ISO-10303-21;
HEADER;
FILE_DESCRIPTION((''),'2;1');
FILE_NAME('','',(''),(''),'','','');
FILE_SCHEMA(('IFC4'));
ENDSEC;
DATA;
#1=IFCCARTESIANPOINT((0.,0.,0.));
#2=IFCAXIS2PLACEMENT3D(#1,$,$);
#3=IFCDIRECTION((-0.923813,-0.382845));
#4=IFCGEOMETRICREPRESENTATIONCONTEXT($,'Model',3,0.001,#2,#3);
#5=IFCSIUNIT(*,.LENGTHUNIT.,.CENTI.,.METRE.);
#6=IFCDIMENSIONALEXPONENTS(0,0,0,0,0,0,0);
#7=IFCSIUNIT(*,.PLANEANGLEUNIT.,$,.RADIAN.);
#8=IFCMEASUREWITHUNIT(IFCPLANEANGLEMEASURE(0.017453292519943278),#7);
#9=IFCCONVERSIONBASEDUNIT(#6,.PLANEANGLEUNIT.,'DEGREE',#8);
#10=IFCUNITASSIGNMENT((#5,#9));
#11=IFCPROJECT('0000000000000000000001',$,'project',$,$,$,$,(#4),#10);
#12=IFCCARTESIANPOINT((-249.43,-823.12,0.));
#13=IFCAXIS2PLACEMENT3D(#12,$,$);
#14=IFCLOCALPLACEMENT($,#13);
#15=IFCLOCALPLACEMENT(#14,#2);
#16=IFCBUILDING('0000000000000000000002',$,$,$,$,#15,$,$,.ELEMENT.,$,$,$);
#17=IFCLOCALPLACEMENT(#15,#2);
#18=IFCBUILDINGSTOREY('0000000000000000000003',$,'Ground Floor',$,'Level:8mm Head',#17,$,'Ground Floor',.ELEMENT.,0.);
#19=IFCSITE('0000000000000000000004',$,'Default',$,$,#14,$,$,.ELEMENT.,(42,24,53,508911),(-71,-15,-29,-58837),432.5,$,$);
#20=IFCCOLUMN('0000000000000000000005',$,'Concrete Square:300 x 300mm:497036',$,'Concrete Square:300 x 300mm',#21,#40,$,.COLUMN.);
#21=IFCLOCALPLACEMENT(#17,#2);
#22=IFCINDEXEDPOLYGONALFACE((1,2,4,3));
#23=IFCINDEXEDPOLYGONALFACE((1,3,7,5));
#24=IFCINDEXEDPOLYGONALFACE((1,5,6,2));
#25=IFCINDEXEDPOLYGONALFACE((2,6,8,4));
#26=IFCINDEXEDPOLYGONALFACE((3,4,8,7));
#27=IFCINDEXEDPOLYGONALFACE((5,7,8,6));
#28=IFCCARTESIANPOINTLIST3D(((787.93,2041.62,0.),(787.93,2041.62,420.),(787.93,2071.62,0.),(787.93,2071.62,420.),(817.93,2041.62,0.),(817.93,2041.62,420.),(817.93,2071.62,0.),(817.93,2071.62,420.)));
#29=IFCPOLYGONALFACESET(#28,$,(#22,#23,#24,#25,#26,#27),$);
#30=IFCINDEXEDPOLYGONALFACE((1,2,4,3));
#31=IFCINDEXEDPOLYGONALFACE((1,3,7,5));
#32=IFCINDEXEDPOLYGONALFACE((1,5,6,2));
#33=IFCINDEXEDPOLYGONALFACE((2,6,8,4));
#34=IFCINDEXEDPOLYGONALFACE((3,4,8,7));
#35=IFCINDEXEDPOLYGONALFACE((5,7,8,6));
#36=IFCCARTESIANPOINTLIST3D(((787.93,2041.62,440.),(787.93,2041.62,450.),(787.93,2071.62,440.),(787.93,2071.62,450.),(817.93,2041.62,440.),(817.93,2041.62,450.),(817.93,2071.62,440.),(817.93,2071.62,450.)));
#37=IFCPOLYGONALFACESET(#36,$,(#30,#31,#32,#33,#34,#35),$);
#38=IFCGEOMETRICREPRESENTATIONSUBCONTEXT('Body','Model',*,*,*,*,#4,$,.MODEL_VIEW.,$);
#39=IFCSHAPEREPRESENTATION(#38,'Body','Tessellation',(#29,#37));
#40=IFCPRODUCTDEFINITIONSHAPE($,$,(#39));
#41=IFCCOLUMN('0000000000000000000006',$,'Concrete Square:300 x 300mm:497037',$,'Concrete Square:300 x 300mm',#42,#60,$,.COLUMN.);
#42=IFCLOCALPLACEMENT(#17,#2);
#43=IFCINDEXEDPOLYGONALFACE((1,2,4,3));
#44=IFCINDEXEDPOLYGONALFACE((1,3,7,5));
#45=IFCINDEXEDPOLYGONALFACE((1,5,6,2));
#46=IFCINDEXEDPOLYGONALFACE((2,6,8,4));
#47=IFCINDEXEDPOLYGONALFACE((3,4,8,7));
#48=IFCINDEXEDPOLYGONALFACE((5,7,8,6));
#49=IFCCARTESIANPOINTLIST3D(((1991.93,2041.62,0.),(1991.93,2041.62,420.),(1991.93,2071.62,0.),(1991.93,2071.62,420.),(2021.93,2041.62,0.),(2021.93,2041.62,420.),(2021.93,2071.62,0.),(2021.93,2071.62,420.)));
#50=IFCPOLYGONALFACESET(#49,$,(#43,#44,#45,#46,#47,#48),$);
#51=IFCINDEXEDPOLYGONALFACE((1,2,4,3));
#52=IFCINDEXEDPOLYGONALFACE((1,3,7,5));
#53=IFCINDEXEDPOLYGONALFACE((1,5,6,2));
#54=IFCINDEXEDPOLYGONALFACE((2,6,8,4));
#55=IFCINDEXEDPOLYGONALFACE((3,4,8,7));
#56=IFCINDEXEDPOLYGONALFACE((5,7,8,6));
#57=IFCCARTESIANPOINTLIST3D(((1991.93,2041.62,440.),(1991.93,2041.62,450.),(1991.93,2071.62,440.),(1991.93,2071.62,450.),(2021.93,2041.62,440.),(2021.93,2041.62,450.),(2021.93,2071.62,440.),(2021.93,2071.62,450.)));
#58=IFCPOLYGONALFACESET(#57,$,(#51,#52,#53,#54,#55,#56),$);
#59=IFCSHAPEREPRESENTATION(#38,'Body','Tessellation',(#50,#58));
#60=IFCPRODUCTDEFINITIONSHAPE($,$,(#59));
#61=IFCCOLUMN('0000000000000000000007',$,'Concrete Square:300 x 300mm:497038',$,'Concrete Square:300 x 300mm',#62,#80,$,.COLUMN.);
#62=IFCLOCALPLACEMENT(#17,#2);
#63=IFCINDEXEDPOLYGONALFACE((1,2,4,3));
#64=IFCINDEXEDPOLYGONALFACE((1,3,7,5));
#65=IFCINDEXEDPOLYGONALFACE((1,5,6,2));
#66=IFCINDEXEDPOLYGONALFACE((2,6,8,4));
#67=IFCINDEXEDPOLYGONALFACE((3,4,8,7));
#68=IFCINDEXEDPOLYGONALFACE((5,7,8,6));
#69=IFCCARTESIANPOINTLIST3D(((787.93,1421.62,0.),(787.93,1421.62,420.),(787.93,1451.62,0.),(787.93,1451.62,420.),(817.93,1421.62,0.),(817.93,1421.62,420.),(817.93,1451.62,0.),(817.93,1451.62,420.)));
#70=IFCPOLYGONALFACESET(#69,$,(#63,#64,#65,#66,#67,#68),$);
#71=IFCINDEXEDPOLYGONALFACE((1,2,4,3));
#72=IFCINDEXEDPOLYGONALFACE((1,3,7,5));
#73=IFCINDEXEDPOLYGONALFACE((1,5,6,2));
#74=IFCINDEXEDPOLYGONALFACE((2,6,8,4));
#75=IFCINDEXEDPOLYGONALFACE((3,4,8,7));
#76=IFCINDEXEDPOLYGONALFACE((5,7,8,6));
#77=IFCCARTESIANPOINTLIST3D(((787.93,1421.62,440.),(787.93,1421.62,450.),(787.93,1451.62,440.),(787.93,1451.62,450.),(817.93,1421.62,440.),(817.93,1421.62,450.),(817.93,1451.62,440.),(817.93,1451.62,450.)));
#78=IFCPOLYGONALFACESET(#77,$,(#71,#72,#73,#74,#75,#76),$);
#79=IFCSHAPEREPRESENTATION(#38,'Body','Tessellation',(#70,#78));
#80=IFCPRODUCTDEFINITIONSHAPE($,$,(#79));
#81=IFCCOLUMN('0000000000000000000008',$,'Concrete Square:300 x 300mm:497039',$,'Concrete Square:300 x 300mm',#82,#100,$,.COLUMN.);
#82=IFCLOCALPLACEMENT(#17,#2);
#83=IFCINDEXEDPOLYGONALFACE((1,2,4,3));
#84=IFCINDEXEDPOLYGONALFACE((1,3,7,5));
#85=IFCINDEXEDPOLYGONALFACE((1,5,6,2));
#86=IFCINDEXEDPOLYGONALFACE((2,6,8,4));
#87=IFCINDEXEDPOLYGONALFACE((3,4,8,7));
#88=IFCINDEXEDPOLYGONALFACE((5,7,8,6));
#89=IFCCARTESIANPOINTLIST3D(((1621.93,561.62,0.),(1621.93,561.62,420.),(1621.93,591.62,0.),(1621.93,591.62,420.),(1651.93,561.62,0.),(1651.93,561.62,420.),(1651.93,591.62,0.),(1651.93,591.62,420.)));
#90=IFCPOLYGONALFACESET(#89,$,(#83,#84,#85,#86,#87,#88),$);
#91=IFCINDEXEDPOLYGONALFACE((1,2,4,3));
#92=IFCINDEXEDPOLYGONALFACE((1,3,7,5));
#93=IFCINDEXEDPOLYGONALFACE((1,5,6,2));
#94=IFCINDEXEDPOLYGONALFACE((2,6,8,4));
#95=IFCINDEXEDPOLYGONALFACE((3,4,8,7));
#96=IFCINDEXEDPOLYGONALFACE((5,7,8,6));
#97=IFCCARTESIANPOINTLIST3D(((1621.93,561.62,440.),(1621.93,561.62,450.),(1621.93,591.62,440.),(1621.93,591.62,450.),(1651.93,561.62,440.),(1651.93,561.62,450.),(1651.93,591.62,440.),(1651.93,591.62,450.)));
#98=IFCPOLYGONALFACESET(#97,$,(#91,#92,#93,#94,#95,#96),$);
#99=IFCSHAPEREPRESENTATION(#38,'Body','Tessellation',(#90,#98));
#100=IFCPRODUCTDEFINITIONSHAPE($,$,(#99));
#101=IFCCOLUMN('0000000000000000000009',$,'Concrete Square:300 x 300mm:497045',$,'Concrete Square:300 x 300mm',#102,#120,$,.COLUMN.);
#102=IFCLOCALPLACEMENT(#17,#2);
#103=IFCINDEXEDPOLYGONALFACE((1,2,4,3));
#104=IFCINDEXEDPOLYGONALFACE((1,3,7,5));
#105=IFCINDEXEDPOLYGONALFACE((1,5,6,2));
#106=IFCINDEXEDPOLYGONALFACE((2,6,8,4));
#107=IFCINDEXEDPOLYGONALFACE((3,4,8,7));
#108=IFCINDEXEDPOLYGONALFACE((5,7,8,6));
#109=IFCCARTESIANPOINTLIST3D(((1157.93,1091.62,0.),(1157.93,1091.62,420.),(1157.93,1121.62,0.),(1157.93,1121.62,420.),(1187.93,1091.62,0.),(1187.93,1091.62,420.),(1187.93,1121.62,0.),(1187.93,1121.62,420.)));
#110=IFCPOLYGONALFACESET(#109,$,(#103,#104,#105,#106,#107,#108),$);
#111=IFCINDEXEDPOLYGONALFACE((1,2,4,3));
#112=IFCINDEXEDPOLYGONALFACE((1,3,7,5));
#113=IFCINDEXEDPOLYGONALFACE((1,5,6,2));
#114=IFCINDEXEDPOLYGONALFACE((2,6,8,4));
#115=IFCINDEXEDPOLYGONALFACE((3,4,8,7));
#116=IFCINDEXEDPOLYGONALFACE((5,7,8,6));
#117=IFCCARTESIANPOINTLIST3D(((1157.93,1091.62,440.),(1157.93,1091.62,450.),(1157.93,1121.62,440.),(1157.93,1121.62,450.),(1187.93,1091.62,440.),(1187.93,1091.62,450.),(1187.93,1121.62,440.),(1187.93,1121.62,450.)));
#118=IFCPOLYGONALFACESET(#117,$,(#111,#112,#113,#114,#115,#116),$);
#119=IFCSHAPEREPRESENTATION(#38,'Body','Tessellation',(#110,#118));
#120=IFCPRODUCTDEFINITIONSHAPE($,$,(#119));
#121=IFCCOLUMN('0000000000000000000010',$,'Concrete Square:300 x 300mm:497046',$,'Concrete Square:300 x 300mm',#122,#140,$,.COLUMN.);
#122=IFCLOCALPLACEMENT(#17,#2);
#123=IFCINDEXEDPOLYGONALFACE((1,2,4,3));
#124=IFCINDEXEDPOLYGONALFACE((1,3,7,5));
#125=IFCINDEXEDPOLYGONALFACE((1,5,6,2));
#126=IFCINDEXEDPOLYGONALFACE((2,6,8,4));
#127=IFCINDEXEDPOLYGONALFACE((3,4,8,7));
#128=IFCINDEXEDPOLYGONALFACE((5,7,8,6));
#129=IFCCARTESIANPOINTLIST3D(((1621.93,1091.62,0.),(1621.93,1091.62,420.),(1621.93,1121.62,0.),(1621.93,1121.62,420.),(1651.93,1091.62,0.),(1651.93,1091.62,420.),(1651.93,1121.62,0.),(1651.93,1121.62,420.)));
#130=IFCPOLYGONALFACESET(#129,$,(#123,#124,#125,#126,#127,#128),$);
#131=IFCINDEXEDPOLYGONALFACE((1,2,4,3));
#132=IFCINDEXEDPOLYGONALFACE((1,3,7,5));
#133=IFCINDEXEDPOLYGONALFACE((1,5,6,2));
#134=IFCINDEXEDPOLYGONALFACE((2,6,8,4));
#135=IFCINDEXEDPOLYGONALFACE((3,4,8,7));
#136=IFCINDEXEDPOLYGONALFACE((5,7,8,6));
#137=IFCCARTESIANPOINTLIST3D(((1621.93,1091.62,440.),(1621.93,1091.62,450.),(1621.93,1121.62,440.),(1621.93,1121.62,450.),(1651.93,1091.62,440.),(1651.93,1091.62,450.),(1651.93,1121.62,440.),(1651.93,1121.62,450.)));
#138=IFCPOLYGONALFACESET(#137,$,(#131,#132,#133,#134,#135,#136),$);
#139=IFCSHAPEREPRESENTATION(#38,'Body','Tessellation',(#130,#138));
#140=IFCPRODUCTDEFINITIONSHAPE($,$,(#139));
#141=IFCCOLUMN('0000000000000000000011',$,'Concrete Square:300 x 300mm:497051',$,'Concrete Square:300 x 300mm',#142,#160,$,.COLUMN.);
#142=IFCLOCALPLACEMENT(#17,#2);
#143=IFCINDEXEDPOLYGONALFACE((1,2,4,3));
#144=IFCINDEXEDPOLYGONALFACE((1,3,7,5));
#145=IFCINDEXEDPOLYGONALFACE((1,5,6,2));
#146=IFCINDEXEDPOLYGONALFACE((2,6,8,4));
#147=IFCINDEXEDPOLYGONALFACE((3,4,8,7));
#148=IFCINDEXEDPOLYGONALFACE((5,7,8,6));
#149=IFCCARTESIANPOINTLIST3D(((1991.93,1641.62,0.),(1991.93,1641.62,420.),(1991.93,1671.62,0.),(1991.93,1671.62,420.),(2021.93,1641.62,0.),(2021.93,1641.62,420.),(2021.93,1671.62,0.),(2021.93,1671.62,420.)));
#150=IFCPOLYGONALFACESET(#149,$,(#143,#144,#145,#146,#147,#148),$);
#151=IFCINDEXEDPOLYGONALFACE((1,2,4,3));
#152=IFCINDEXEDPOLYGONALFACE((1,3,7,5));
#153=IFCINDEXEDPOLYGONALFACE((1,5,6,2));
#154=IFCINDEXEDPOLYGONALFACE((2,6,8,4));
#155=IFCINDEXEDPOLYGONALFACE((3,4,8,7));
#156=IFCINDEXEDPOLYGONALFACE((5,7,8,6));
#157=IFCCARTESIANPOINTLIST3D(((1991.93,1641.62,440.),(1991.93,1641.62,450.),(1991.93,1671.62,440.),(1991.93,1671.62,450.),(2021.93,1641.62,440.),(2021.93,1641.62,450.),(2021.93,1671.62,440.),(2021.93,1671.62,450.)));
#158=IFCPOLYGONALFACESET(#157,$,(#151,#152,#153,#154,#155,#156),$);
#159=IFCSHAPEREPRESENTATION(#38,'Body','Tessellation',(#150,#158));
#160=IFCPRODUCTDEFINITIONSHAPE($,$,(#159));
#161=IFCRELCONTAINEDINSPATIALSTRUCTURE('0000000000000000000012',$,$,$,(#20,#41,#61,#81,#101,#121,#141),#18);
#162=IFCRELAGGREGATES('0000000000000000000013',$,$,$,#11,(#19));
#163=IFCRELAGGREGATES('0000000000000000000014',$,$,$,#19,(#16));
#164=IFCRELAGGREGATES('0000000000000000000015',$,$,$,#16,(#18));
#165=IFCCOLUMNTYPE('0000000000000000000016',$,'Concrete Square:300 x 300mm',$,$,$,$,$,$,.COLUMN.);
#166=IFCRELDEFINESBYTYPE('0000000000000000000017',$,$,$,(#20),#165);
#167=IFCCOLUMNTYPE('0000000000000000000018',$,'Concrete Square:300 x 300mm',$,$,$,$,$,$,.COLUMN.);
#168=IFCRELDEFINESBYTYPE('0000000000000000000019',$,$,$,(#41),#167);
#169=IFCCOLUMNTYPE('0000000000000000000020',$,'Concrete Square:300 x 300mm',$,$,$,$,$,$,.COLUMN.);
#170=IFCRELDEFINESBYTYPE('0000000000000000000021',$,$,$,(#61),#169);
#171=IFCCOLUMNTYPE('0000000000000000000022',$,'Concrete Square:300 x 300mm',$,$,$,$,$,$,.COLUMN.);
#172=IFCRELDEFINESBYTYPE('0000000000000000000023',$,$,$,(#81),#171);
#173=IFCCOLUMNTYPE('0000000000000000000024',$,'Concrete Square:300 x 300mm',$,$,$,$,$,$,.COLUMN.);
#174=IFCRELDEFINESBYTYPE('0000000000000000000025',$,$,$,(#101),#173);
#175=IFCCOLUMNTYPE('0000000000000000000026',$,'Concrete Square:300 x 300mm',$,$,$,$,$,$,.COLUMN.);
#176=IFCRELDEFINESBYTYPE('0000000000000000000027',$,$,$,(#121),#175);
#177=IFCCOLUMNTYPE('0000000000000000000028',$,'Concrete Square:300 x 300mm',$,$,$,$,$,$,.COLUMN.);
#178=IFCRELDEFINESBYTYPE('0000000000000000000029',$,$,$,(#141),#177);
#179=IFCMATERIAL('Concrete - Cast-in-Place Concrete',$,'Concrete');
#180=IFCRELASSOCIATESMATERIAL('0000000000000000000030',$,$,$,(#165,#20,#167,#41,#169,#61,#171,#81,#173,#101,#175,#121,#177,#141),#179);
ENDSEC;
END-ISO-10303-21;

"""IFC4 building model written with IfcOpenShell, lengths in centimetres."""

from ifc_helpers import new_model, entity, si_unit, converted_unit, direction, frame, origin, place, context, subcontext, project, spatial, indexed_curve, outline, extrude, source, transform, mapped, material, type_object, type_shapes, element, save


model = new_model("IFC4")

# Units and contexts
model_context = context("Model", 3, precision=0.001, world=origin(), true_north=direction((-0.923813, -0.382845)))
body_context = subcontext(model_context, "Body", "Model", "MODEL_VIEW")
ifc_project = project(units=[si_unit("LENGTHUNIT", "METRE", prefix="CENTI"), converted_unit("PLANEANGLEUNIT", "DEGREE", entity("IfcPlaneAngleMeasure", 0.017453292519943278), si_unit("PLANEANGLEUNIT", "RADIAN"), dimensions=[0, 0, 0, 0, 0, 0, 0])], contexts=[model_context])

# Site, building, storey
site_placement = place(None, frame((-249.43, -823.12, 0.0)))
site = spatial("IfcSite", under=ifc_project, at=site_placement, Name="Default", CompositionType="ELEMENT", RefLatitude=(42, 24, 53, 508911), RefLongitude=(-71, -15, -29, -58837), RefElevation=432.5)
building_placement = place(site_placement, origin())
building = spatial("IfcBuilding", under=site, at=building_placement, CompositionType="ELEMENT")
storey_placement = place(building_placement, origin())
storey = spatial("IfcBuildingStorey", under=building, at=storey_placement, Name="Ground Floor", ObjectType="Level:8mm Head", LongName="Ground Floor", CompositionType="ELEMENT", Elevation=0.0)

# Columns
ifc_material_1 = material(Name="Concrete - Cast-in-Place Concrete", Category="Concrete")
column_type_1 = type_object("IfcColumnType", Name="Concrete Square:300 x 300mm", PredefinedType="COLUMN", material=ifc_material_1)
shared_shape_1 = source(origin(), body_context, "Body", "SweptSolid", [
    extrude(outline(indexed_curve([(-15.0, -15.0), (15.0, -15.0), (15.0, 15.0), (-15.0, 15.0), (-15.0, -15.0)], self_intersect=False)), frame((802.93, 2056.62, 0.0), z_axis=(0.0, 0.0, 1.0), x_axis=(-1.0, 0.0, 0.0)), (0.0, 0.0, 1.0), 420.0),
    extrude(outline(indexed_curve([(-15.0, -15.0), (15.0, -15.0), (15.0, 15.0), (-15.0, 15.0), (-15.0, -15.0)], self_intersect=False)), frame((802.93, 2056.62, 440.0), z_axis=(0.0, 0.0, 1.0), x_axis=(-1.0, 0.0, 0.0)), (0.0, 0.0, 1.0), 10.0),
])
type_shapes(column_type_1, [shared_shape_1])
column_1_placement = place(storey_placement, origin())
element("IfcColumn", 1, at=column_1_placement, inside=storey, type_object=column_type_1, material=ifc_material_1, Name="Concrete Square:300 x 300mm:497036", ObjectType="Concrete Square:300 x 300mm", PredefinedType="COLUMN", context=body_context, shape_type="MappedRepresentation", body=[
    mapped(shared_shape_1, transform((0.0, 0.0, 0.0), scale=1.0)),
])
column_type_2 = type_object("IfcColumnType", Name="Concrete Square:300 x 300mm", PredefinedType="COLUMN", material=ifc_material_1)
shared_shape_2 = source(origin(), body_context, "Body", "SweptSolid", [
    extrude(outline(indexed_curve([(-15.0, -15.0), (15.0, -15.0), (15.0, 15.0), (-15.0, 15.0), (-15.0, -15.0)], self_intersect=False)), frame((2006.93, 2056.62, 0.0), z_axis=(0.0, 0.0, 1.0), x_axis=(-1.0, 0.0, 0.0)), (0.0, 0.0, 1.0), 420.0),
    extrude(outline(indexed_curve([(-15.0, -15.0), (15.0, -15.0), (15.0, 15.0), (-15.0, 15.0), (-15.0, -15.0)], self_intersect=False)), frame((2006.93, 2056.62, 440.0), z_axis=(0.0, 0.0, 1.0), x_axis=(-1.0, 0.0, 0.0)), (0.0, 0.0, 1.0), 10.0),
])
type_shapes(column_type_2, [shared_shape_2])
column_2_placement = place(storey_placement, origin())
element("IfcColumn", 2, at=column_2_placement, inside=storey, type_object=column_type_2, material=ifc_material_1, Name="Concrete Square:300 x 300mm:497037", ObjectType="Concrete Square:300 x 300mm", PredefinedType="COLUMN", context=body_context, shape_type="MappedRepresentation", body=[
    mapped(shared_shape_2, transform((0.0, 0.0, 0.0), scale=1.0)),
])
column_type_3 = type_object("IfcColumnType", Name="Concrete Square:300 x 300mm", PredefinedType="COLUMN", material=ifc_material_1)
shared_shape_3 = source(origin(), body_context, "Body", "SweptSolid", [
    extrude(outline(indexed_curve([(-15.0, -15.0), (15.0, -15.0), (15.0, 15.0), (-15.0, 15.0), (-15.0, -15.0)], self_intersect=False)), frame((802.93, 1436.62, 0.0), z_axis=(0.0, 0.0, 1.0), x_axis=(-1.0, 0.0, 0.0)), (0.0, 0.0, 1.0), 420.0),
    extrude(outline(indexed_curve([(-15.0, -15.0), (15.0, -15.0), (15.0, 15.0), (-15.0, 15.0), (-15.0, -15.0)], self_intersect=False)), frame((802.93, 1436.62, 440.0), z_axis=(0.0, 0.0, 1.0), x_axis=(-1.0, 0.0, 0.0)), (0.0, 0.0, 1.0), 10.0),
])
type_shapes(column_type_3, [shared_shape_3])
column_3_placement = place(storey_placement, origin())
element("IfcColumn", 3, at=column_3_placement, inside=storey, type_object=column_type_3, material=ifc_material_1, Name="Concrete Square:300 x 300mm:497038", ObjectType="Concrete Square:300 x 300mm", PredefinedType="COLUMN", context=body_context, shape_type="MappedRepresentation", body=[
    mapped(shared_shape_3, transform((0.0, 0.0, 0.0), scale=1.0)),
])
column_type_4 = type_object("IfcColumnType", Name="Concrete Square:300 x 300mm", PredefinedType="COLUMN", material=ifc_material_1)
shared_shape_4 = source(origin(), body_context, "Body", "SweptSolid", [
    extrude(outline(indexed_curve([(-15.0, -15.0), (15.0, -15.0), (15.0, 15.0), (-15.0, 15.0), (-15.0, -15.0)], self_intersect=False)), frame((1636.93, 576.62, 0.0), z_axis=(0.0, 0.0, 1.0), x_axis=(-1.0, 0.0, 0.0)), (0.0, 0.0, 1.0), 420.0),
    extrude(outline(indexed_curve([(-15.0, -15.0), (15.0, -15.0), (15.0, 15.0), (-15.0, 15.0), (-15.0, -15.0)], self_intersect=False)), frame((1636.93, 576.62, 440.0), z_axis=(0.0, 0.0, 1.0), x_axis=(-1.0, 0.0, 0.0)), (0.0, 0.0, 1.0), 10.0),
])
type_shapes(column_type_4, [shared_shape_4])
column_4_placement = place(storey_placement, origin())
element("IfcColumn", 4, at=column_4_placement, inside=storey, type_object=column_type_4, material=ifc_material_1, Name="Concrete Square:300 x 300mm:497039", ObjectType="Concrete Square:300 x 300mm", PredefinedType="COLUMN", context=body_context, shape_type="MappedRepresentation", body=[
    mapped(shared_shape_4, transform((0.0, 0.0, 0.0), scale=1.0)),
])
column_type_5 = type_object("IfcColumnType", Name="Concrete Square:300 x 300mm", PredefinedType="COLUMN", material=ifc_material_1)
shared_shape_5 = source(origin(), body_context, "Body", "SweptSolid", [
    extrude(outline(indexed_curve([(-15.0, -15.0), (15.0, -15.0), (15.0, 15.0), (-15.0, 15.0), (-15.0, -15.0)], self_intersect=False)), frame((1172.93, 1106.62, 0.0), z_axis=(0.0, 0.0, 1.0), x_axis=(-1.0, 0.0, 0.0)), (0.0, 0.0, 1.0), 420.0),
    extrude(outline(indexed_curve([(-15.0, -15.0), (15.0, -15.0), (15.0, 15.0), (-15.0, 15.0), (-15.0, -15.0)], self_intersect=False)), frame((1172.93, 1106.62, 440.0), z_axis=(0.0, 0.0, 1.0), x_axis=(-1.0, 0.0, 0.0)), (0.0, 0.0, 1.0), 10.0),
])
type_shapes(column_type_5, [shared_shape_5])
column_5_placement = place(storey_placement, origin())
element("IfcColumn", 5, at=column_5_placement, inside=storey, type_object=column_type_5, material=ifc_material_1, Name="Concrete Square:300 x 300mm:497045", ObjectType="Concrete Square:300 x 300mm", PredefinedType="COLUMN", context=body_context, shape_type="MappedRepresentation", body=[
    mapped(shared_shape_5, transform((0.0, 0.0, 0.0), scale=1.0)),
])
column_type_6 = type_object("IfcColumnType", Name="Concrete Square:300 x 300mm", PredefinedType="COLUMN", material=ifc_material_1)
shared_shape_6 = source(origin(), body_context, "Body", "SweptSolid", [
    extrude(outline(indexed_curve([(-15.0, -15.0), (15.0, -15.0), (15.0, 15.0), (-15.0, 15.0), (-15.0, -15.0)], self_intersect=False)), frame((1636.93, 1106.62, 0.0), z_axis=(0.0, 0.0, 1.0), x_axis=(-1.0, 0.0, 0.0)), (0.0, 0.0, 1.0), 420.0),
    extrude(outline(indexed_curve([(-15.0, -15.0), (15.0, -15.0), (15.0, 15.0), (-15.0, 15.0), (-15.0, -15.0)], self_intersect=False)), frame((1636.93, 1106.62, 440.0), z_axis=(0.0, 0.0, 1.0), x_axis=(-1.0, 0.0, 0.0)), (0.0, 0.0, 1.0), 10.0),
])
type_shapes(column_type_6, [shared_shape_6])
column_6_placement = place(storey_placement, origin())
element("IfcColumn", 6, at=column_6_placement, inside=storey, type_object=column_type_6, material=ifc_material_1, Name="Concrete Square:300 x 300mm:497046", ObjectType="Concrete Square:300 x 300mm", PredefinedType="COLUMN", context=body_context, shape_type="MappedRepresentation", body=[
    mapped(shared_shape_6, transform((0.0, 0.0, 0.0), scale=1.0)),
])
column_type_7 = type_object("IfcColumnType", Name="Concrete Square:300 x 300mm", PredefinedType="COLUMN", material=ifc_material_1)
shared_shape_7 = source(origin(), body_context, "Body", "SweptSolid", [
    extrude(outline(indexed_curve([(-15.0, -15.0), (15.0, -15.0), (15.0, 15.0), (-15.0, 15.0), (-15.0, -15.0)], self_intersect=False)), frame((2006.93, 1656.62, 0.0), z_axis=(0.0, 0.0, 1.0), x_axis=(-1.0, 0.0, 0.0)), (0.0, 0.0, 1.0), 420.0),
    extrude(outline(indexed_curve([(-15.0, -15.0), (15.0, -15.0), (15.0, 15.0), (-15.0, 15.0), (-15.0, -15.0)], self_intersect=False)), frame((2006.93, 1656.62, 440.0), z_axis=(0.0, 0.0, 1.0), x_axis=(-1.0, 0.0, 0.0)), (0.0, 0.0, 1.0), 10.0),
])
type_shapes(column_type_7, [shared_shape_7])
column_7_placement = place(storey_placement, origin())
element("IfcColumn", 7, at=column_7_placement, inside=storey, type_object=column_type_7, material=ifc_material_1, Name="Concrete Square:300 x 300mm:497051", ObjectType="Concrete Square:300 x 300mm", PredefinedType="COLUMN", context=body_context, shape_type="MappedRepresentation", body=[
    mapped(shared_shape_7, transform((0.0, 0.0, 0.0), scale=1.0)),
])

save(model, "model.ifc")
